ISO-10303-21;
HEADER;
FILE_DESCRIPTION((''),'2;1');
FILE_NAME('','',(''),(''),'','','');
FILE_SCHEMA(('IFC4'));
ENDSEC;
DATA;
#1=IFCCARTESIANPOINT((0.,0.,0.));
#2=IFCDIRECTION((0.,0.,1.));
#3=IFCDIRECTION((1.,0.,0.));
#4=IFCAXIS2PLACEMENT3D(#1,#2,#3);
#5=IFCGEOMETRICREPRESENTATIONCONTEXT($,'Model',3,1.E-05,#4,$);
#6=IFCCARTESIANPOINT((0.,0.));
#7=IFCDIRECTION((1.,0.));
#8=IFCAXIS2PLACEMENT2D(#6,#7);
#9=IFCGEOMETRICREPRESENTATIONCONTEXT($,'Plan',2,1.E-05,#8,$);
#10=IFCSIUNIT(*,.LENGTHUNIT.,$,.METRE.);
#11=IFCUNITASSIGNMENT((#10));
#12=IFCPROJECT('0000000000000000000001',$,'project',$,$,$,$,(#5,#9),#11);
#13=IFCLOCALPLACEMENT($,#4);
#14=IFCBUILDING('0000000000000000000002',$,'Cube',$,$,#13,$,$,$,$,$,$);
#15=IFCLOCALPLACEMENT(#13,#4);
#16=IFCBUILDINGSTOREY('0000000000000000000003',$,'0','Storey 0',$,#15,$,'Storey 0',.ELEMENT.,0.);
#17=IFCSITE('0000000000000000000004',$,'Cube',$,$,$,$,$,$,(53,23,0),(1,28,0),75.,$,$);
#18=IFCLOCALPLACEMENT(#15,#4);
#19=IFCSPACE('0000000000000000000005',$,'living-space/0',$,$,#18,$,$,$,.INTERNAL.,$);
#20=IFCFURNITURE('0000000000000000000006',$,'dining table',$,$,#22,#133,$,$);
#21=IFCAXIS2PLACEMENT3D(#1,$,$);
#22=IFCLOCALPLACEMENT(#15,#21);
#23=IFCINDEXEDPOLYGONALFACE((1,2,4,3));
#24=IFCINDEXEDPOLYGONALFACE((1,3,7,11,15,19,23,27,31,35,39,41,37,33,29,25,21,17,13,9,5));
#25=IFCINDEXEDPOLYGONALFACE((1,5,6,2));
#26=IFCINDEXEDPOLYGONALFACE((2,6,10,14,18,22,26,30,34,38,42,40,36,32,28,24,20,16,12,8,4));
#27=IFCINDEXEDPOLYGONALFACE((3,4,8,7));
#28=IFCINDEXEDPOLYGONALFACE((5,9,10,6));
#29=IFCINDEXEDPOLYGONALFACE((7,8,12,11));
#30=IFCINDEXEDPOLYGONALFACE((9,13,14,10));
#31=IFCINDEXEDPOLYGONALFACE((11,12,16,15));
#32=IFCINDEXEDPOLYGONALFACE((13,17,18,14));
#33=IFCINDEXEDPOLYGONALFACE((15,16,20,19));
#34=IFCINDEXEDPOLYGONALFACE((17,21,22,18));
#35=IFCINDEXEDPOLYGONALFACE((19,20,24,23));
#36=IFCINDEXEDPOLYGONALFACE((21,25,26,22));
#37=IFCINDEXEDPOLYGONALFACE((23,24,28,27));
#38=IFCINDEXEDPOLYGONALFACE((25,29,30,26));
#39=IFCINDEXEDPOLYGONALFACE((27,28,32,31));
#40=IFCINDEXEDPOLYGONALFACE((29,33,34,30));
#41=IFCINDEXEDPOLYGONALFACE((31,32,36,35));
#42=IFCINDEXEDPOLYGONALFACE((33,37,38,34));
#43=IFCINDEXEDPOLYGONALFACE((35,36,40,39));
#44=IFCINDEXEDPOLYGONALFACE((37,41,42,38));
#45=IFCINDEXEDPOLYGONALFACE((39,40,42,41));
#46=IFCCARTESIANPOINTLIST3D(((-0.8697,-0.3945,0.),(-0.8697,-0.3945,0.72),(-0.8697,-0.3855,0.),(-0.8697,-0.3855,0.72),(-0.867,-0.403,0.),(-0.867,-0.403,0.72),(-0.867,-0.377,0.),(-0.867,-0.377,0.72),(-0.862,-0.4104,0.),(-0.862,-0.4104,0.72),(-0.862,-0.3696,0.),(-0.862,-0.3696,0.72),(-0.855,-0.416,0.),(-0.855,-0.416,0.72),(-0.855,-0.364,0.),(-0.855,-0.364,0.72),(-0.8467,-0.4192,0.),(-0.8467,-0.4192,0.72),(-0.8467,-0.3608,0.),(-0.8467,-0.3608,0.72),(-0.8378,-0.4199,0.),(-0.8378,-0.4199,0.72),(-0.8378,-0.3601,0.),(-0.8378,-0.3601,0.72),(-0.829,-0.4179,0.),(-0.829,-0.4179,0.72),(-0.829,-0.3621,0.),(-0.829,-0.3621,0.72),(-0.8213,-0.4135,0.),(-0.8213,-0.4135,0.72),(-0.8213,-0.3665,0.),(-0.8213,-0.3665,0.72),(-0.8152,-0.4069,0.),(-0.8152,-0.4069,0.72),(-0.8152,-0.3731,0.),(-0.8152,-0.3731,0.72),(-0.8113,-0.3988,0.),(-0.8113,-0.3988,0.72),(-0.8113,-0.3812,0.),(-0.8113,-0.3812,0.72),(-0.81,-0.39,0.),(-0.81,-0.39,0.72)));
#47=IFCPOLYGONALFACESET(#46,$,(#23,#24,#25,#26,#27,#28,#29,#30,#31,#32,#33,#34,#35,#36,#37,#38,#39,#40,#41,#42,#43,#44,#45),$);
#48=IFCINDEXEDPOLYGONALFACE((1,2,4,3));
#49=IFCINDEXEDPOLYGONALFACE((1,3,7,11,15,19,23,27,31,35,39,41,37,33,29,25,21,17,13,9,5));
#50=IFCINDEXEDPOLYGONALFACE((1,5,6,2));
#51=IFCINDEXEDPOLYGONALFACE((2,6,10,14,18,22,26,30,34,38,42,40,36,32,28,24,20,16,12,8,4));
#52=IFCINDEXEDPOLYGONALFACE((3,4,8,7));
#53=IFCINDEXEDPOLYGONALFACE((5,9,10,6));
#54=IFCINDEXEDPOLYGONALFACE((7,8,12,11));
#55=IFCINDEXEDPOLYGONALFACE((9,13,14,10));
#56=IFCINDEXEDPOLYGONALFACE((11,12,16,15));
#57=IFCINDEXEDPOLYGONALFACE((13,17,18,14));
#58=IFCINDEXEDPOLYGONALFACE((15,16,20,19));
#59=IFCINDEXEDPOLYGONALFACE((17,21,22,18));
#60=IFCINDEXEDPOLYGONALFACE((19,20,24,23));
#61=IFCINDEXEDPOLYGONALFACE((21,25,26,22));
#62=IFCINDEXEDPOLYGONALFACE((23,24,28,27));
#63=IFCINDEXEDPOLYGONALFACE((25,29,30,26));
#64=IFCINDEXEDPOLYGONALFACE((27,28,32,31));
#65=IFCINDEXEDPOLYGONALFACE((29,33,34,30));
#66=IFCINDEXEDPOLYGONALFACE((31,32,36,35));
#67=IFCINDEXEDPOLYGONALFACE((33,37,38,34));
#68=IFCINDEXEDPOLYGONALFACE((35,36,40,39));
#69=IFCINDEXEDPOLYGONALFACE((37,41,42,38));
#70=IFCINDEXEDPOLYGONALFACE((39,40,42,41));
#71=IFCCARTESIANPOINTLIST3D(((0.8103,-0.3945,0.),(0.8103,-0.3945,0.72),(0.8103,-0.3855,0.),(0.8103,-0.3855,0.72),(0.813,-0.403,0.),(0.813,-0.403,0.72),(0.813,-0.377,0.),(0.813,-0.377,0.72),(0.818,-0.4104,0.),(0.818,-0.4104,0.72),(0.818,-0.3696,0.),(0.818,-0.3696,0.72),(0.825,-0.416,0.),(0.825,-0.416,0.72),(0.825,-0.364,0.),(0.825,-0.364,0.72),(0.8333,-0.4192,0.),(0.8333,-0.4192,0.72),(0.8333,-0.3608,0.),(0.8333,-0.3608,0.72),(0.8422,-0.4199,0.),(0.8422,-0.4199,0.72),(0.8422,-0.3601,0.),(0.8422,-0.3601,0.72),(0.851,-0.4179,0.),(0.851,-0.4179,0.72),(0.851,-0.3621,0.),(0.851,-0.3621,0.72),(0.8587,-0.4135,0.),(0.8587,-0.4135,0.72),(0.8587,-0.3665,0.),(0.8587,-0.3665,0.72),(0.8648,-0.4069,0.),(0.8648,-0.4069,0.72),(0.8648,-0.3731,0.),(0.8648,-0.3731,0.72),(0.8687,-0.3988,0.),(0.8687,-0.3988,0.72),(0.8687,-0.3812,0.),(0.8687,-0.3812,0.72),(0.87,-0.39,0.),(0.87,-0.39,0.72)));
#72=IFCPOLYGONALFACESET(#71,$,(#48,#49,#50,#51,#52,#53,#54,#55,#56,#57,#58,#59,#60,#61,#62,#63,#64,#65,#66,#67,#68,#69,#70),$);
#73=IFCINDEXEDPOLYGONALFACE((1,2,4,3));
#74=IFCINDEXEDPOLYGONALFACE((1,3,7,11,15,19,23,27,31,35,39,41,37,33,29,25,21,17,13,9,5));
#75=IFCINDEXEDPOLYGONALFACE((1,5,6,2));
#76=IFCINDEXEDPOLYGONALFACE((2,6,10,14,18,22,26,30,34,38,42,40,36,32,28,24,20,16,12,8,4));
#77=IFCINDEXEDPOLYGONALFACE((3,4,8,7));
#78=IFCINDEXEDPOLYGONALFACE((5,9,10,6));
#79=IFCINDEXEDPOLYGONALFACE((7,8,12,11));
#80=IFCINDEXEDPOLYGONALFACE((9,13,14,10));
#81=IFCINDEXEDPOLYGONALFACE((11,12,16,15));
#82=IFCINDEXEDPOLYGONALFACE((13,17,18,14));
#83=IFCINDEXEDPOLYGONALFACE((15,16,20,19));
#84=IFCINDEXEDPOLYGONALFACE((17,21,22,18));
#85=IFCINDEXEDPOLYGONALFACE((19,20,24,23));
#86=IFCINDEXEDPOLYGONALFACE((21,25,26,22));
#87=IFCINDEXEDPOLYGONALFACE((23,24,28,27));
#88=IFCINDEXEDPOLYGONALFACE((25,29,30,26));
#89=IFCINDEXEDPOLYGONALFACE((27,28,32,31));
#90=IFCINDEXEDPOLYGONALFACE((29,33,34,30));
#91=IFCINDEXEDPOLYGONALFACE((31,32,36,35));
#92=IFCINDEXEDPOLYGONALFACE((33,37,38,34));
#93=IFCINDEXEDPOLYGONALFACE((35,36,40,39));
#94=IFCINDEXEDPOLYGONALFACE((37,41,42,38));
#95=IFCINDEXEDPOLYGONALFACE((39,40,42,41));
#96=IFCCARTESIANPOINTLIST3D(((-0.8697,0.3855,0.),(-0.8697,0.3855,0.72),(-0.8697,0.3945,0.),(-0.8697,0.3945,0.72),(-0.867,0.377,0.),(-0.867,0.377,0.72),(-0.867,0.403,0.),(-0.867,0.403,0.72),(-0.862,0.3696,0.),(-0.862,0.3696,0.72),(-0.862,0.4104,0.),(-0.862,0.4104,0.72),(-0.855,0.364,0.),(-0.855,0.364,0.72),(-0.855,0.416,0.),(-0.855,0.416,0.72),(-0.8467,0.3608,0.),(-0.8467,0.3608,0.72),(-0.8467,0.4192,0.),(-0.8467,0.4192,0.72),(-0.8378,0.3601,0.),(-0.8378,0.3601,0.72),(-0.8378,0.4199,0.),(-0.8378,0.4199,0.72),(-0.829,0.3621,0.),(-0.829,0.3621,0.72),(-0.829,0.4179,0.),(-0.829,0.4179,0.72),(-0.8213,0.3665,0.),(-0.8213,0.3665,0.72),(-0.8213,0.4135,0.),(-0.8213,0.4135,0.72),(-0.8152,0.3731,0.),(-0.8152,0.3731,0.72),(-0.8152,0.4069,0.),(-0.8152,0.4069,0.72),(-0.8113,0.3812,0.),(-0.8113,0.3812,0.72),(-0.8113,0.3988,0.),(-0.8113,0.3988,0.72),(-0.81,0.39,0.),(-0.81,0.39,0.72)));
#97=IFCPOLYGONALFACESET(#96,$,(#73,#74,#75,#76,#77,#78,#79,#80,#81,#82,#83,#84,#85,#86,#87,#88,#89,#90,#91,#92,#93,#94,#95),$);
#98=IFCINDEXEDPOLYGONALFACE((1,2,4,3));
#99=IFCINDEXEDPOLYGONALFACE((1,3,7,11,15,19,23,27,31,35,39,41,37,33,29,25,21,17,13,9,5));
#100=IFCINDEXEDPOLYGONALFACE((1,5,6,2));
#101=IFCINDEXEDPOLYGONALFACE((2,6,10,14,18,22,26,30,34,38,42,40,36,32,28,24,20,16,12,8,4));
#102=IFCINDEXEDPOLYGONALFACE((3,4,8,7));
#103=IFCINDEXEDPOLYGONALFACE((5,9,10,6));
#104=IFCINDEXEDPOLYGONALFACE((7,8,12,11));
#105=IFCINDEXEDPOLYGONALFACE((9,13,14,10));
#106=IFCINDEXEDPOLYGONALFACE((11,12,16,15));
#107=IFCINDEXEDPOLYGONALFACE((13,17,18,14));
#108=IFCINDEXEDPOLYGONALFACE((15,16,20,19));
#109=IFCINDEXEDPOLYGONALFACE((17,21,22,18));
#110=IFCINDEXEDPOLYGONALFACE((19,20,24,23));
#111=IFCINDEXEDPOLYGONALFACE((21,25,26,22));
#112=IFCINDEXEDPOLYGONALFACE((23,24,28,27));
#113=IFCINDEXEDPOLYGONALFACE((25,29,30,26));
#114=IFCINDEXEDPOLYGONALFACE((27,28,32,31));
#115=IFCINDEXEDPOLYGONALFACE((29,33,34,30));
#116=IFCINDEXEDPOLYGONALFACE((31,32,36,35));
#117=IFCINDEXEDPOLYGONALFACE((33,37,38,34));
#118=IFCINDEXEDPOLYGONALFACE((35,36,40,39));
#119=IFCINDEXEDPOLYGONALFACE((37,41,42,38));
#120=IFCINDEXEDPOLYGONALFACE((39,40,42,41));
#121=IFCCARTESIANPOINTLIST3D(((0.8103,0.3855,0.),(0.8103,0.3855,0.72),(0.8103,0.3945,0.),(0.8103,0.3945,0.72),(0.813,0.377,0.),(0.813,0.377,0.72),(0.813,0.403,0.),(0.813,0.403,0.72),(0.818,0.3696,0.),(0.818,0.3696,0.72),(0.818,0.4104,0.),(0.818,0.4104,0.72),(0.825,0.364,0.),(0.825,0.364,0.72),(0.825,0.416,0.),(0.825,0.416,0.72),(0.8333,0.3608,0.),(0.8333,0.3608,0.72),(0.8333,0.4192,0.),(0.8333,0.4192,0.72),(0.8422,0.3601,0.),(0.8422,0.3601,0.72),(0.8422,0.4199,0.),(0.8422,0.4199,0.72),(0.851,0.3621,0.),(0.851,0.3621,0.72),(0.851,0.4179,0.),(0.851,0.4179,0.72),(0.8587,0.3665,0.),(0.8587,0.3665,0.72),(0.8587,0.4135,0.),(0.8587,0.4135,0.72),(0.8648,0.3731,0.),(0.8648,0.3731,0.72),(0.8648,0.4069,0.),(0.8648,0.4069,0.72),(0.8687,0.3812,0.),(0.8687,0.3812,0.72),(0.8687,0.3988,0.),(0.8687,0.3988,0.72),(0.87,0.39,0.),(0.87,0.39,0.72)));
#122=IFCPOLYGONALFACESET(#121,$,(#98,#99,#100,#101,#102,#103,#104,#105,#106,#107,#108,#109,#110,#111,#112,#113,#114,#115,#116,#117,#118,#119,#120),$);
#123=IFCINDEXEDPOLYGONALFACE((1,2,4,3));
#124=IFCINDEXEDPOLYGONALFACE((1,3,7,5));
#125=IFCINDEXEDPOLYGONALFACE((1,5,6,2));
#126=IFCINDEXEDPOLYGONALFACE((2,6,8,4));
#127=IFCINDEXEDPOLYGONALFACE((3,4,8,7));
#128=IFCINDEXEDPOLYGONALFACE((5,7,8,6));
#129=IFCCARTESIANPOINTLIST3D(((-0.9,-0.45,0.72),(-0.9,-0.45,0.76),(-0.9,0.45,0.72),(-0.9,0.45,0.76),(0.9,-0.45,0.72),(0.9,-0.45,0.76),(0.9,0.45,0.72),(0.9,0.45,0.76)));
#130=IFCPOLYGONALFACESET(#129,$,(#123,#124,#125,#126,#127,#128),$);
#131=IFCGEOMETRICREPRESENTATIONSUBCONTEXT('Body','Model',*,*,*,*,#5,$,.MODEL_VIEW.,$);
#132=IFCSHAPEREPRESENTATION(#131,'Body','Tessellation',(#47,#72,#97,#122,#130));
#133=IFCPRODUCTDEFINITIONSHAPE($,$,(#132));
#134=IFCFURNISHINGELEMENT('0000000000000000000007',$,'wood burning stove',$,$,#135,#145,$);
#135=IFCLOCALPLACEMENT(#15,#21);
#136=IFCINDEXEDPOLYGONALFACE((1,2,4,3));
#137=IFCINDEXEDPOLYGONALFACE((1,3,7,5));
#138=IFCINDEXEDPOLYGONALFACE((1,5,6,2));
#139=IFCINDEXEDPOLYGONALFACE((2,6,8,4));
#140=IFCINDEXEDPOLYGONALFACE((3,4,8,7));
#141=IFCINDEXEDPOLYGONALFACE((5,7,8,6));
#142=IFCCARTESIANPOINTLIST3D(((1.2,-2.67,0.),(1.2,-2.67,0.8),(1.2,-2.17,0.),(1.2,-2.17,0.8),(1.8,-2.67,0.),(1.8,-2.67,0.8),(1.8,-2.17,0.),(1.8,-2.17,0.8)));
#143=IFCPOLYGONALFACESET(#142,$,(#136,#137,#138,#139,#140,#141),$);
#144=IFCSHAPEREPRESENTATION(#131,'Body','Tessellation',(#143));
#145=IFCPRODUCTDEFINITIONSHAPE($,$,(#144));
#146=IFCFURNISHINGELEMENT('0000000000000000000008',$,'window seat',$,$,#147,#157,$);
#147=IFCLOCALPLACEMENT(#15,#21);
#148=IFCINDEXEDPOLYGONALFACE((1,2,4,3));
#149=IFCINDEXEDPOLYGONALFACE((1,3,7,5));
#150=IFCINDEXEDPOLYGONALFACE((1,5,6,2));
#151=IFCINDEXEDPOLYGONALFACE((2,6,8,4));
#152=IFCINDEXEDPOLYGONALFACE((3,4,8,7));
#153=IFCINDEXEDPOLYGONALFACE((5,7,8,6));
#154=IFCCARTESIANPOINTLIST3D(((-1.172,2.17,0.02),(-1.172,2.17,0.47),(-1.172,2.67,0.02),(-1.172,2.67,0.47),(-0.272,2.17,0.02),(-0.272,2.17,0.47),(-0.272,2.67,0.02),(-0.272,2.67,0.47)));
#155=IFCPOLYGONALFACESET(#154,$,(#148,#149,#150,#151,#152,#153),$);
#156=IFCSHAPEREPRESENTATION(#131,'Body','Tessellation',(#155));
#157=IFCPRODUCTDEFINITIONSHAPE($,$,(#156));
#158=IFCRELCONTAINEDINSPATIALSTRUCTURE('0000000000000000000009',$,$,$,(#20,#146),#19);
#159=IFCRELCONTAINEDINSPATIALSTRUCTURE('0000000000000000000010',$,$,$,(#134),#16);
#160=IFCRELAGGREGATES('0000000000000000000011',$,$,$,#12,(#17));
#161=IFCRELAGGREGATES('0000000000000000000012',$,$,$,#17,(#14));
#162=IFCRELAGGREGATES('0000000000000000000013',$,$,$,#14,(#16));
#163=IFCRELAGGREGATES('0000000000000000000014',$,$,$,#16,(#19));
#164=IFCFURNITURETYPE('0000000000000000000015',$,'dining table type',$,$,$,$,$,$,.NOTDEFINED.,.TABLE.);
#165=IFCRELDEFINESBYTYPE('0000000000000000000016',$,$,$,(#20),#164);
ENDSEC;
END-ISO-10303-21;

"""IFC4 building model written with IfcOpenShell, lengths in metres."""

from ifc_helpers import new_model, entity, si_unit, frame, origin_with_axes, origin_2d_with_axis, place, context, subcontext, project, spatial, line, indexed_curve, outline, extrude, source, transform, mapped, type_object, type_shapes, element, save


model = new_model("IFC4")

# Units and contexts
model_context = context("Model", 3, precision=1e-05, world=origin_with_axes())
plan_context = context("Plan", 2, precision=1e-05, world=origin_2d_with_axis())
body_context_1 = subcontext(model_context, "Body", "Model", "MODEL_VIEW")
ifc_project = project(units=[si_unit("LENGTHUNIT", "METRE")], contexts=[model_context, plan_context])

# Site, building, storey
site = spatial("IfcSite", under=ifc_project, Name="Cube", RefLatitude=(53, 23, 0), RefLongitude=(1, 28, 0), RefElevation=75.0)
building_placement = place(None, origin_with_axes())
building = spatial("IfcBuilding", under=site, at=building_placement, Name="Cube")
storey_placement = place(building_placement, origin_with_axes())
storey = spatial("IfcBuildingStorey", under=building, at=storey_placement, Name="0", Description="Storey 0", LongName="Storey 0", CompositionType="ELEMENT", Elevation=0.0)

# Shared definitions
space_placement = place(storey_placement, origin_with_axes())
space = spatial("IfcSpace", under=storey, at=space_placement, Name="living-space/0", PredefinedType="INTERNAL")

# Furniture
furniture_type_1 = type_object("IfcFurnitureType", Name="dining table type", AssemblyPlace="NOTDEFINED", PredefinedType="TABLE")
shared_circle = entity("IfcCircle", entity("IfcAxis2Placement2D", entity("IfcCartesianPoint", [0.0, 0.0])), 0.03)
shared_shape_1 = source(origin_with_axes(), body_context_1, "Body", "SweptSolid", [
    entity("IfcExtrudedAreaSolid", entity("IfcArbitraryClosedProfileDef", "AREA", None, shared_circle), entity("IfcAxis2Placement3D", entity("IfcCartesianPoint", [-0.84, -0.39, 0.0]), entity("IfcDirection", [0.0, 0.0, 1.0]), entity("IfcDirection", [1.0, 0.0, 0.0])), entity("IfcDirection", [0.0, 0.0, 1.0]), 0.72),
    entity("IfcExtrudedAreaSolid", entity("IfcArbitraryClosedProfileDef", "AREA", None, shared_circle), entity("IfcAxis2Placement3D", entity("IfcCartesianPoint", [0.84, -0.39, 0.0]), entity("IfcDirection", [0.0, 0.0, 1.0]), entity("IfcDirection", [1.0, 0.0, 0.0])), entity("IfcDirection", [0.0, 0.0, 1.0]), 0.72),
    entity("IfcExtrudedAreaSolid", entity("IfcArbitraryClosedProfileDef", "AREA", None, shared_circle), entity("IfcAxis2Placement3D", entity("IfcCartesianPoint", [-0.84, 0.39, 0.0]), entity("IfcDirection", [0.0, 0.0, 1.0]), entity("IfcDirection", [1.0, 0.0, 0.0])), entity("IfcDirection", [0.0, 0.0, 1.0]), 0.72),
    entity("IfcExtrudedAreaSolid", entity("IfcArbitraryClosedProfileDef", "AREA", None, shared_circle), entity("IfcAxis2Placement3D", entity("IfcCartesianPoint", [0.84, 0.39, 0.0]), entity("IfcDirection", [0.0, 0.0, 1.0]), entity("IfcDirection", [1.0, 0.0, 0.0])), entity("IfcDirection", [0.0, 0.0, 1.0]), 0.72),
    extrude(outline(indexed_curve([(-0.9, -0.45), (0.9, -0.45), (0.9, 0.45), (-0.9, 0.45)], segments=[line(1, 2, 3, 4, 1)])), frame((0.0, 0.0, 0.72), z_axis=(0.0, 0.0, 1.0), x_axis=(1.0, 0.0, 0.0)), (0.0, 0.0, 1.0), 0.04),
])
type_shapes(furniture_type_1, [shared_shape_1])
furniture_placement = place(space_placement, origin_with_axes())
element("IfcFurniture", 1, at=furniture_placement, inside=space, type_object=furniture_type_1, Name="dining table", context=body_context_1, shape_type="MappedRepresentation", body=[
    mapped(shared_shape_1, transform((0.0, 0.0, 0.0), x_axis=(1.0, 0.0, 0.0), y_axis=(0.0, 1.0, 0.0), z_axis=(0.0, 0.0, 1.0), scale=1.0)),
])

# Furnishing elements
furnishing_1_placement = place(storey_placement, frame((1.2, -2.67, 0.0), z_axis=(0.0, 0.0, 1.0), x_axis=(1.0, 0.0, 0.0)))
element("IfcFurnishingElement", 2, at=furnishing_1_placement, inside=storey, Name="wood burning stove", context=body_context_1, shape_type="SweptSolid", body=[
    extrude(outline(indexed_curve([(0.0, 0.0), (0.6, 0.0), (0.6, 0.5), (0.0, 0.5)])), None, (0.0, 0.0, 1.0), 0.8),
])
furnishing_2_placement = place(space_placement, frame((-1.172, 2.17, 0.02), z_axis=(0.0, 0.0, 1.0), x_axis=(1.0, 0.0, 0.0)))
element("IfcFurnishingElement", 3, at=furnishing_2_placement, inside=space, Name="window seat", context=body_context_1, shape_type="SweptSolid", body=[
    extrude(outline(indexed_curve([(0.0, 0.0), (0.9, 0.0), (0.9, 0.5), (0.0, 0.5)])), None, (0.0, 0.0, 1.0), 0.45),
])

save(model, "model.ifc")
